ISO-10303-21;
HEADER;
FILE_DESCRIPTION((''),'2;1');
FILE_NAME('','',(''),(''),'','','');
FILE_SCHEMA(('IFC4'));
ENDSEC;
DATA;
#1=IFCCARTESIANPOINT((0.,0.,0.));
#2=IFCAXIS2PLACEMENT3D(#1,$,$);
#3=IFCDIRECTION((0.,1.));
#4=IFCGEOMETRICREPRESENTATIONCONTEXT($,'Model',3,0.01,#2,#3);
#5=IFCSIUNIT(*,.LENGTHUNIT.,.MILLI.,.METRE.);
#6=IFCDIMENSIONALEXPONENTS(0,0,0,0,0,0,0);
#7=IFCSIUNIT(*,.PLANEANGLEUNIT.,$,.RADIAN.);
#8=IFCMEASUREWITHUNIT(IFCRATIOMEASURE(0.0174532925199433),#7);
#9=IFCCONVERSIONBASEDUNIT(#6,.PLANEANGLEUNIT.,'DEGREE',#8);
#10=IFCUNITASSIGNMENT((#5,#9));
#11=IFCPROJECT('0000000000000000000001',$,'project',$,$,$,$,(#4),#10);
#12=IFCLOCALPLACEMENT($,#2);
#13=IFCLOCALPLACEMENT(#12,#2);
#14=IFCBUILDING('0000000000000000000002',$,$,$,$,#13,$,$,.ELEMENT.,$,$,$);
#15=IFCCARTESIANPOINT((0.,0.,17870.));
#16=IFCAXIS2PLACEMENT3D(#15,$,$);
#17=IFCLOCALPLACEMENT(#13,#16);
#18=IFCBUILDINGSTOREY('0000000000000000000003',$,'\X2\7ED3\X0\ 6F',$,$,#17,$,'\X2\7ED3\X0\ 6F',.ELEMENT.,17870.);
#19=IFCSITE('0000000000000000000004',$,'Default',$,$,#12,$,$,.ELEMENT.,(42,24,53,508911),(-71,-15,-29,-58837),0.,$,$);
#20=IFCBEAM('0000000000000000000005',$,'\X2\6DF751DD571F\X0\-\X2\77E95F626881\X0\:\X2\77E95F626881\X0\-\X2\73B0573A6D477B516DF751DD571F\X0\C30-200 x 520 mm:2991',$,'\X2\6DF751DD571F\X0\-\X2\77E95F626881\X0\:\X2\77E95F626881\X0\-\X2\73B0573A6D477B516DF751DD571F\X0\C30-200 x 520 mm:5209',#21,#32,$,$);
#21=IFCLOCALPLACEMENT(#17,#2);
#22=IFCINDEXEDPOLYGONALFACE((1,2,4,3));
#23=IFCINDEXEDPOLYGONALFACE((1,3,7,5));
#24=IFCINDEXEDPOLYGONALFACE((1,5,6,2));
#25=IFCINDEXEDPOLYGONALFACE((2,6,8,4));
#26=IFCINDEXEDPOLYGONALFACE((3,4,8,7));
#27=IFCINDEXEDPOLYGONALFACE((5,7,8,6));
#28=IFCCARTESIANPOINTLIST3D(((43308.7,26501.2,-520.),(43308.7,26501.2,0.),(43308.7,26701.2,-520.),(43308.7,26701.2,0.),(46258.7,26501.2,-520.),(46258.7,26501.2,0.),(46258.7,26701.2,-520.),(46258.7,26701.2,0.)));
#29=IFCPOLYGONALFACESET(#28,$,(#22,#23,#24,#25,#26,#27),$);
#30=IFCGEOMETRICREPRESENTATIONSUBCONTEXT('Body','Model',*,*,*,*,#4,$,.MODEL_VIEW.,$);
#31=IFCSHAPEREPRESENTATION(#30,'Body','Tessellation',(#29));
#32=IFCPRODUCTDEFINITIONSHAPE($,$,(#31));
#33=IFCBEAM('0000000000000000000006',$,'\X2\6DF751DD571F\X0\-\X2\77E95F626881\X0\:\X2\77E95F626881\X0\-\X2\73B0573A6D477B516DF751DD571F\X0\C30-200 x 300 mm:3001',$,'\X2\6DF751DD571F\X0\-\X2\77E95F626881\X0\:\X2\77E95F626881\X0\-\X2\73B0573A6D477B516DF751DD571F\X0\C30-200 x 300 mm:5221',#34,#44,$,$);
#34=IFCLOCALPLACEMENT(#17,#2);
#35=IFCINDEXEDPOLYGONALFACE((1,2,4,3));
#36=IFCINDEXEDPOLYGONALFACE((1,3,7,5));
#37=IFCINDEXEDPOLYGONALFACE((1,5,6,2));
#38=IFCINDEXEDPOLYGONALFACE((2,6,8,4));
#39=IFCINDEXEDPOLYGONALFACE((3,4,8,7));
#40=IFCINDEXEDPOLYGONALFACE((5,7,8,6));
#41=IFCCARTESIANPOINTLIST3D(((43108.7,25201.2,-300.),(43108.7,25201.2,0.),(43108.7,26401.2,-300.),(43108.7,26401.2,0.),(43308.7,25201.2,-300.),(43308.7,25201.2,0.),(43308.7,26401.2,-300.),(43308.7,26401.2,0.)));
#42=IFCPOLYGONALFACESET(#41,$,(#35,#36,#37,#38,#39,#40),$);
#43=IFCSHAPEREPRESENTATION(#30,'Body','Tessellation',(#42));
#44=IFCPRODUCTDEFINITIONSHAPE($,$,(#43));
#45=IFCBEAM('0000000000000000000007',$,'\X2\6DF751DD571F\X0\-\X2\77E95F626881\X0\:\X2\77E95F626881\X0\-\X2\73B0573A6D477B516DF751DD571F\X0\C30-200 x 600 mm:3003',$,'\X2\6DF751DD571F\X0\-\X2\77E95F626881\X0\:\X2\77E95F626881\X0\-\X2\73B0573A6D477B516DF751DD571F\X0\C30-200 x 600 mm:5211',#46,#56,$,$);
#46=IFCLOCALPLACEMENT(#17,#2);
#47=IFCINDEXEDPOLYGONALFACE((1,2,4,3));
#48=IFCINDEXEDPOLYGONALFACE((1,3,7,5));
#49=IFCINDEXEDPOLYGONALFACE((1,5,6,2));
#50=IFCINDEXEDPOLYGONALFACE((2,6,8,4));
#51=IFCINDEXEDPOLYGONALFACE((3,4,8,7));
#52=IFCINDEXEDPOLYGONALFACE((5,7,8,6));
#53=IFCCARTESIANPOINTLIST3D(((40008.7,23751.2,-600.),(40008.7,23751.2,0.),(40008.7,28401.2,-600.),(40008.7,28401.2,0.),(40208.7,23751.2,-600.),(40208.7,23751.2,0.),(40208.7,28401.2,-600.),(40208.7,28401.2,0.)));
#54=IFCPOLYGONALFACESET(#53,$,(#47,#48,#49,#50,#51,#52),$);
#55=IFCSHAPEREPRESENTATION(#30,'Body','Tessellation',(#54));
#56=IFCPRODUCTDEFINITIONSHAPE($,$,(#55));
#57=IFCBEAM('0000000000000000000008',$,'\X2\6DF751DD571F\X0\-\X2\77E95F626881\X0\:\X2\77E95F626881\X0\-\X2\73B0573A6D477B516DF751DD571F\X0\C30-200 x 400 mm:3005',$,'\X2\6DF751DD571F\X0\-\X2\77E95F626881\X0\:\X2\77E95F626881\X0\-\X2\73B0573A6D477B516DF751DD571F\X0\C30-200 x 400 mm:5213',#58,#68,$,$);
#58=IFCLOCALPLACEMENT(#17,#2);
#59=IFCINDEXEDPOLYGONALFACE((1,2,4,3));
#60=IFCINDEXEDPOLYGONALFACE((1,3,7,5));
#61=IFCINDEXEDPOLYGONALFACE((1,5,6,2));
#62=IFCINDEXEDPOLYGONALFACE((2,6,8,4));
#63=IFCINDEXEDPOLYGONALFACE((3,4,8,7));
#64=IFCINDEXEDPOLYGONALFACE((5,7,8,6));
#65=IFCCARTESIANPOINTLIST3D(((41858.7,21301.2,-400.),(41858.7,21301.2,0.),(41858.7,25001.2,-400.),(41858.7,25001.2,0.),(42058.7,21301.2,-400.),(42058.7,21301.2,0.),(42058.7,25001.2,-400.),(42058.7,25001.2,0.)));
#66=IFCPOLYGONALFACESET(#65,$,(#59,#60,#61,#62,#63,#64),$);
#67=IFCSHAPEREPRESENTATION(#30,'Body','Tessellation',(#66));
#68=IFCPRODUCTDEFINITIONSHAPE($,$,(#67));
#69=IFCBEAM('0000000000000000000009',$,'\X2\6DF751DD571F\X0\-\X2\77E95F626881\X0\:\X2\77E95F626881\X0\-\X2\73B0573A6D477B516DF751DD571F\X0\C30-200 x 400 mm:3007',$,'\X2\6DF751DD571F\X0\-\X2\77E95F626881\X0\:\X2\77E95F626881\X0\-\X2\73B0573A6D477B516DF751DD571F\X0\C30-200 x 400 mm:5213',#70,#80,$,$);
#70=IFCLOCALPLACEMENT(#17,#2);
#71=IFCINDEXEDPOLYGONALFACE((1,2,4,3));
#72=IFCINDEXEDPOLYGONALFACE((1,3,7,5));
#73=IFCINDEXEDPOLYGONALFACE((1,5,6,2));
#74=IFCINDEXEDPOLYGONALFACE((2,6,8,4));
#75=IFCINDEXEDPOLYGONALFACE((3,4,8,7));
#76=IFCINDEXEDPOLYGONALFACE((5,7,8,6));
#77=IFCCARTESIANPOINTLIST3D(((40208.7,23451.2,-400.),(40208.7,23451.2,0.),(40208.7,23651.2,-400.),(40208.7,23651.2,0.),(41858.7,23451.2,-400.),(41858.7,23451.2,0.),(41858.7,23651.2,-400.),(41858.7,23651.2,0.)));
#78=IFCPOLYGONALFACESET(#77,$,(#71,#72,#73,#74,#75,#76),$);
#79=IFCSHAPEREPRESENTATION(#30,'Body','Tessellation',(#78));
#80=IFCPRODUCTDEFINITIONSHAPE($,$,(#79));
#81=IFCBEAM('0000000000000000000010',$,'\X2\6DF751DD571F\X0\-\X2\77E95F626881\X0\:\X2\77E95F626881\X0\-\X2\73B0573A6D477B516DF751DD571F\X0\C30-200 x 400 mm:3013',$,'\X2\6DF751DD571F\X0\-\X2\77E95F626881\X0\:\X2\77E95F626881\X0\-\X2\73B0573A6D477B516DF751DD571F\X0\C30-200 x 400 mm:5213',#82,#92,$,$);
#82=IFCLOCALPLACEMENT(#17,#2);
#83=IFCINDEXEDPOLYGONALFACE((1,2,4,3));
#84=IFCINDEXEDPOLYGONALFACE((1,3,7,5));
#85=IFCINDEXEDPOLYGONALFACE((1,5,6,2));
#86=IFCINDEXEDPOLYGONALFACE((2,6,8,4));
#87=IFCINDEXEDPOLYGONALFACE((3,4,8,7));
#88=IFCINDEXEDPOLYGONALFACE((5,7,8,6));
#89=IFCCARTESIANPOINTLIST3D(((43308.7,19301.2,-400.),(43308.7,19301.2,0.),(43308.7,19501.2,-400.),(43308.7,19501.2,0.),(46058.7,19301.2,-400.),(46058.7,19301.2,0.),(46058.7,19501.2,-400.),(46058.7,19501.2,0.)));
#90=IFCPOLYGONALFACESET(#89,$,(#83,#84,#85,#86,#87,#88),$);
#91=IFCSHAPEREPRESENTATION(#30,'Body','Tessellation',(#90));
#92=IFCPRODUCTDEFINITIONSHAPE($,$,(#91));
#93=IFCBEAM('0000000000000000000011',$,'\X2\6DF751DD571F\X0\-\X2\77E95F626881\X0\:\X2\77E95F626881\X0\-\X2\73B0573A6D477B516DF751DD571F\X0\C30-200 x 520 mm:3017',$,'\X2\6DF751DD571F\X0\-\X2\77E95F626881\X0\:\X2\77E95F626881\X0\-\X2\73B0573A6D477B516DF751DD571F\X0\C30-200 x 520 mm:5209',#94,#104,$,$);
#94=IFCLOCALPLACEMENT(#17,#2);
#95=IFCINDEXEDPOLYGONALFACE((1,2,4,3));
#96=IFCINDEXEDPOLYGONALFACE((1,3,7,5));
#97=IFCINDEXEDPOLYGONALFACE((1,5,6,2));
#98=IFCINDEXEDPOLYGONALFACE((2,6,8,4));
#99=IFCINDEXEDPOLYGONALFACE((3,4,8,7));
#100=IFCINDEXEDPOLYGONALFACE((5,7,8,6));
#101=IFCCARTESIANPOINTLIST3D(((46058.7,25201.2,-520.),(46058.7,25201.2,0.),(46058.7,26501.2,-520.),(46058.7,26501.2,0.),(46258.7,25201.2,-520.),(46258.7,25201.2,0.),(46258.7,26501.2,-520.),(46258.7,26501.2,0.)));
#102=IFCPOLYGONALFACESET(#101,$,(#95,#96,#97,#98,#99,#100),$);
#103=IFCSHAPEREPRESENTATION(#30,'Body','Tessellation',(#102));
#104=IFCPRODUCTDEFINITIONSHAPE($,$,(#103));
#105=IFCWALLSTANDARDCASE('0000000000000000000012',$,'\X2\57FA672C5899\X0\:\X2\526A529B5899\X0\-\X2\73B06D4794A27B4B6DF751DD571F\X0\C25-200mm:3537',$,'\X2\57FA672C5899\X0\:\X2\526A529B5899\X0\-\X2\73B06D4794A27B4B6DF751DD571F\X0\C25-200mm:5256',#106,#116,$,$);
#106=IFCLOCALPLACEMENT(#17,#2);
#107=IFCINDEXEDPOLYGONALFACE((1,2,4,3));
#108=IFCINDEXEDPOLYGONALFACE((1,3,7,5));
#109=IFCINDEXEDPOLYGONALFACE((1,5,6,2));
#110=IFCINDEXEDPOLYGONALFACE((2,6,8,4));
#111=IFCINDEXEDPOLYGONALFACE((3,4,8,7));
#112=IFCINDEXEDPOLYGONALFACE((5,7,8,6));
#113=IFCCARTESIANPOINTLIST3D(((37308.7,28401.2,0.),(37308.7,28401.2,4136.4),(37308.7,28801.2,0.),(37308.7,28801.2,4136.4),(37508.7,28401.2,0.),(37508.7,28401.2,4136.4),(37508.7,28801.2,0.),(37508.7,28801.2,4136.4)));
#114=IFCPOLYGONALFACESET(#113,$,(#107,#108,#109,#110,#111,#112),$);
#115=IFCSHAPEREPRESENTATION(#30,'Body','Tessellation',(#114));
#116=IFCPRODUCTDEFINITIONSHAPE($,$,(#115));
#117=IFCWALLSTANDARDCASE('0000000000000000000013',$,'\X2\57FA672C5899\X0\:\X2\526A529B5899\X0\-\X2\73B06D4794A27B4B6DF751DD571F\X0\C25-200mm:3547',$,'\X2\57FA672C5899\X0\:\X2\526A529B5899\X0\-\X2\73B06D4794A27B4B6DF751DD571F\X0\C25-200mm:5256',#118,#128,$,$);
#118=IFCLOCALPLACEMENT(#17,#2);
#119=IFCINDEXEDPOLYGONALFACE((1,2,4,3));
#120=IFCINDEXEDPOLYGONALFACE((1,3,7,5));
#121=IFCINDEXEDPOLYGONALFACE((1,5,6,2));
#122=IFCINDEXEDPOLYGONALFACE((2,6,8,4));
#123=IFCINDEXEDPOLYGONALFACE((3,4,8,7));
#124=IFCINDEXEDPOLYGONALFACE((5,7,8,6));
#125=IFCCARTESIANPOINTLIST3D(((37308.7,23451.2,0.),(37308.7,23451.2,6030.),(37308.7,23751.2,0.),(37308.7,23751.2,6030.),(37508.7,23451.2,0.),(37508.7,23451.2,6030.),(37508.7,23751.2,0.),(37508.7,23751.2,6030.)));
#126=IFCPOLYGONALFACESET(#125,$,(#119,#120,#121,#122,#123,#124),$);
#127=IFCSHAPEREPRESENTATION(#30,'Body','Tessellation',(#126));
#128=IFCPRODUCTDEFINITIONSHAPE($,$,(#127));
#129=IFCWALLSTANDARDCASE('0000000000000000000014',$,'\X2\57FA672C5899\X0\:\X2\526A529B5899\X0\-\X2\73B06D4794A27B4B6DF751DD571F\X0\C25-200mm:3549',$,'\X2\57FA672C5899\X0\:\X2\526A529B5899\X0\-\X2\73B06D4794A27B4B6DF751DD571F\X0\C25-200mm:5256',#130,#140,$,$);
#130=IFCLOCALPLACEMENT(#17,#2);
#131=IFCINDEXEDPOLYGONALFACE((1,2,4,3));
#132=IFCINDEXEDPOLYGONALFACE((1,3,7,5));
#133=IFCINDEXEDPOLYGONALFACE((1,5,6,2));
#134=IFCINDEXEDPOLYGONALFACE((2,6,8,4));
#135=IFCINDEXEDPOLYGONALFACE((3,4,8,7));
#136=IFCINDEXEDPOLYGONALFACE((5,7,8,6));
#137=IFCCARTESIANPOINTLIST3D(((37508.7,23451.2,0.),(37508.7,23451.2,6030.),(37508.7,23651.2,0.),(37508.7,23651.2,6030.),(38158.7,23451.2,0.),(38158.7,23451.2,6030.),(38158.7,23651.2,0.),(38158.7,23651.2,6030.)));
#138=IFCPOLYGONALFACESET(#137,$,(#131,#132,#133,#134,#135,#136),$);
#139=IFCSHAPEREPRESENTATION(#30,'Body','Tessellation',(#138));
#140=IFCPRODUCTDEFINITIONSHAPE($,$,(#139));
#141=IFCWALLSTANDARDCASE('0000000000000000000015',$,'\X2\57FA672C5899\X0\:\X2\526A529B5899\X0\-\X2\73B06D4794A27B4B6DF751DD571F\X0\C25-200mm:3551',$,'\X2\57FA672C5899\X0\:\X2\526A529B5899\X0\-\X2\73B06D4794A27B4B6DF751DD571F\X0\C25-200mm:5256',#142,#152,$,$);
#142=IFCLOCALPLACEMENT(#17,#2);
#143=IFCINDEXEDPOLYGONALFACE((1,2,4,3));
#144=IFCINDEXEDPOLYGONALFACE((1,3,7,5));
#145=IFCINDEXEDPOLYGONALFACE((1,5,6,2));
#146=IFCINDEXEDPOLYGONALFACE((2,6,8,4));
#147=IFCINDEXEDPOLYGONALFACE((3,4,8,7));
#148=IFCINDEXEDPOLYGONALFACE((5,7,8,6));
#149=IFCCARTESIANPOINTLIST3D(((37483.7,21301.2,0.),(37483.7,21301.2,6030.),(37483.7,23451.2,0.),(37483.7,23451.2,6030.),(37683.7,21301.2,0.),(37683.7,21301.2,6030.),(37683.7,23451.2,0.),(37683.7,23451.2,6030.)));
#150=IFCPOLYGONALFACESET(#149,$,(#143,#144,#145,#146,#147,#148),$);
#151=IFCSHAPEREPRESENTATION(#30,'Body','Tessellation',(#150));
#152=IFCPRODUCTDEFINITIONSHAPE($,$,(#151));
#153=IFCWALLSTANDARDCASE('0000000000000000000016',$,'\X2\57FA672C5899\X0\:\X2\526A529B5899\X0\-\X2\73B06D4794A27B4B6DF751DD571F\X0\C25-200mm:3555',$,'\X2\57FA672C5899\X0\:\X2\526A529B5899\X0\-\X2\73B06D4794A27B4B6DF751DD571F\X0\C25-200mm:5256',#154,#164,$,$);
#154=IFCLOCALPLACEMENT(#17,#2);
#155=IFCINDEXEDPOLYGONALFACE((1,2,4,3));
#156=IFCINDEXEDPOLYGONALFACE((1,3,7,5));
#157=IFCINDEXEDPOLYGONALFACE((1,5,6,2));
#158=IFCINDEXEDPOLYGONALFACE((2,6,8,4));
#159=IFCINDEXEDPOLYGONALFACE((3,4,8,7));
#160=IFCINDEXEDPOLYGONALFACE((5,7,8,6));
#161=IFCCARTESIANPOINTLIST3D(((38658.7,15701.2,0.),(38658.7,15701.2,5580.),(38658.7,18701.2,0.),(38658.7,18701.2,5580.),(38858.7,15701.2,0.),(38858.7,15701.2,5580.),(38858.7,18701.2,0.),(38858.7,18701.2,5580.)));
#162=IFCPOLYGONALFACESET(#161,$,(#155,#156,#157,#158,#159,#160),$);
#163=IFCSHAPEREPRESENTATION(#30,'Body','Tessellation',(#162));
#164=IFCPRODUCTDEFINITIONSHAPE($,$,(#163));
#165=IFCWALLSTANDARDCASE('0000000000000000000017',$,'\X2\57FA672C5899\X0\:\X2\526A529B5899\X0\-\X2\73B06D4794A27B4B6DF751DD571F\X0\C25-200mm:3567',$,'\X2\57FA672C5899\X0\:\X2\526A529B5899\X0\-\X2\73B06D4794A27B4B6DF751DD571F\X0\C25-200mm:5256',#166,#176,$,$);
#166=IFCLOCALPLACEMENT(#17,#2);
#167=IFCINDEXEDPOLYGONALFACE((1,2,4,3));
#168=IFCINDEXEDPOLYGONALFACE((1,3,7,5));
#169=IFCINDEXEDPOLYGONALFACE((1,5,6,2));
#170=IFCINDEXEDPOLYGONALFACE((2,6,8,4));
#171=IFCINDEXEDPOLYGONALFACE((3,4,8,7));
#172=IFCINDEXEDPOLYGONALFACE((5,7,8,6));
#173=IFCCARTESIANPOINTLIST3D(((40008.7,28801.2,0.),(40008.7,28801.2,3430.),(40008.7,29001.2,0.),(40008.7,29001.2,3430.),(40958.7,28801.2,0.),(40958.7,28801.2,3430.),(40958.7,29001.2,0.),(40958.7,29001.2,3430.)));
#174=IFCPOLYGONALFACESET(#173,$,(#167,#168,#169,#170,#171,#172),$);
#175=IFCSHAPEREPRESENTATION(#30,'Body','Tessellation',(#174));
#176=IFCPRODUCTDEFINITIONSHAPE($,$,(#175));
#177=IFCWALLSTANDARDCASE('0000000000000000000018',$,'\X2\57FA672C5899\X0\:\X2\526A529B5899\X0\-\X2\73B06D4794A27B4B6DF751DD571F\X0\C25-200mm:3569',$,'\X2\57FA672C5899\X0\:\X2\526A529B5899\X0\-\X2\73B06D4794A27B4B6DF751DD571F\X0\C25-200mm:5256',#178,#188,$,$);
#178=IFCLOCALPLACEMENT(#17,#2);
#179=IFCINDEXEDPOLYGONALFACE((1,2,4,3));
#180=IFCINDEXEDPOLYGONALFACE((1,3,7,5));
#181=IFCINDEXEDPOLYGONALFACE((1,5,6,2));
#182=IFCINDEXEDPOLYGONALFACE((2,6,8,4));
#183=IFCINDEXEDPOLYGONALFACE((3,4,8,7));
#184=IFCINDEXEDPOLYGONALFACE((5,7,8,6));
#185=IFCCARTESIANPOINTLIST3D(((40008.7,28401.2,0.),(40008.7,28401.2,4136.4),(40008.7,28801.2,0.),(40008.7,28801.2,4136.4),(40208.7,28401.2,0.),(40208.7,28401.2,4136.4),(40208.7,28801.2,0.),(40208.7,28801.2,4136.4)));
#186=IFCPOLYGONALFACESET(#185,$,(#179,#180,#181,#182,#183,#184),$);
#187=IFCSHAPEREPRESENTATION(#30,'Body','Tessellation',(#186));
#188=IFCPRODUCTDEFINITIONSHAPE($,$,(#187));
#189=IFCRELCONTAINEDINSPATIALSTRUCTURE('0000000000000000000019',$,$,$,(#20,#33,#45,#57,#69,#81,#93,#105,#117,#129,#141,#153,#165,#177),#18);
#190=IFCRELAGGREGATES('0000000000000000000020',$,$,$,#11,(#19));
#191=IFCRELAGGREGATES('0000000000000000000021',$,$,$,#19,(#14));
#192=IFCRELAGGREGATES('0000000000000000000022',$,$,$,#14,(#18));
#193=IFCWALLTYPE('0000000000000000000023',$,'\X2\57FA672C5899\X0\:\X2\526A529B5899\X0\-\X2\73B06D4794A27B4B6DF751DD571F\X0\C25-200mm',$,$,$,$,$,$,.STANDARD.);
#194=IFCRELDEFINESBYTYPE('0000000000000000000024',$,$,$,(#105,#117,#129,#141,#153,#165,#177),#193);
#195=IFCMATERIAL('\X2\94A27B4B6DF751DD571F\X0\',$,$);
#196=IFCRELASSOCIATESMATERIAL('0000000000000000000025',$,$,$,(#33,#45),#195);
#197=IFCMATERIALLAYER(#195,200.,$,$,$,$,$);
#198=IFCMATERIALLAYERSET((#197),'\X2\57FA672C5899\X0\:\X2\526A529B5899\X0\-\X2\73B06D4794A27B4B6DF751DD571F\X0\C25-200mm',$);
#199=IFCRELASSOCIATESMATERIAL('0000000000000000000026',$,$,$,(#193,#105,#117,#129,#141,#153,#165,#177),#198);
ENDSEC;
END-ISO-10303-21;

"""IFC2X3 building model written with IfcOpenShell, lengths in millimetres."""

from ifc_helpers import new_model, entity, si_unit, converted_unit, direction, frame, frame_2d, origin, origin_2d_with_axis, place, context, subcontext, project, spatial, rectangle, extrude, material, layer, layer_set, layer_usage, type_object, element, save


model = new_model("IFC2X3")

# Units and contexts
model_context = context("Model", 3, precision=0.01, world=origin(), true_north=direction((0.0, 1.0)))
body_context = subcontext(model_context, "Body", "Model", "MODEL_VIEW")
ifc_project = project(units=[si_unit("LENGTHUNIT", "METRE", prefix="MILLI"), converted_unit("PLANEANGLEUNIT", "DEGREE", entity("IfcRatioMeasure", 0.0174532925199433), si_unit("PLANEANGLEUNIT", "RADIAN"), dimensions=[0, 0, 0, 0, 0, 0, 0])], contexts=[model_context])

# Site, building, storey
site_placement = place(None, origin())
site = spatial("IfcSite", under=ifc_project, at=site_placement, Name="Default", CompositionType="ELEMENT", RefLatitude=(42, 24, 53, 508911), RefLongitude=(-71, -15, -29, -58837), RefElevation=0.0)
building_placement = place(site_placement, origin())
building = spatial("IfcBuilding", under=site, at=building_placement, CompositionType="ELEMENT")
storey_placement = place(building_placement, frame((0.0, 0.0, 17870.0)))
storey = spatial("IfcBuildingStorey", under=building, at=storey_placement, Name="结 6F", LongName="结 6F", CompositionType="ELEMENT", Elevation=17870.0)

# Beams
ifc_material = material(Name="钢筋混凝土")
beam_1_placement = place(storey_placement, frame((46158.7, 26601.2, 0.0), z_axis=(0.0, 0.0, 1.0), x_axis=(-1.0, 0.0, 0.0)))
element("IfcBeam", 1, at=beam_1_placement, inside=storey, Name="混凝土-矩形梁:矩形梁-现场浇筑混凝土C30-200 x 520 mm:2991", ObjectType="混凝土-矩形梁:矩形梁-现场浇筑混凝土C30-200 x 520 mm:5209", context=body_context, shape_type="SweptSolid", body=[
    extrude(rectangle(XDim=520.0, YDim=200.0, at=frame_2d((0.0, 0.0), x_axis=(1.0, 0.0))), frame((-100.0, 0.0, -260.0), z_axis=(1.0, 0.0, 0.0), x_axis=(0.0, 0.0, -1.0)), (0.0, 0.0, 1.0), 2950.0),
])
beam_2_placement = place(storey_placement, frame((43208.7, 25101.2, 0.0), z_axis=(0.0, 0.0, 1.0), x_axis=(0.0, 1.0, 0.0)))
element("IfcBeam", 2, at=beam_2_placement, inside=storey, material=ifc_material, Name="混凝土-矩形梁:矩形梁-现场浇筑混凝土C30-200 x 300 mm:3001", ObjectType="混凝土-矩形梁:矩形梁-现场浇筑混凝土C30-200 x 300 mm:5221", context=body_context, shape_type="SweptSolid", body=[
    extrude(rectangle(XDim=300.0, YDim=200.0, at=frame_2d((0.0, 0.0), x_axis=(1.0, 0.0))), frame((100.0, 0.0, -150.0), z_axis=(1.0, 0.0, 0.0), x_axis=(0.0, 0.0, -1.0)), (0.0, 0.0, 1.0), 1200.0),
])
beam_3_placement = place(storey_placement, frame((40108.7, 23551.2, 0.0), z_axis=(0.0, 0.0, 1.0), x_axis=(0.0, 1.0, 0.0)))
element("IfcBeam", 3, at=beam_3_placement, inside=storey, material=ifc_material, Name="混凝土-矩形梁:矩形梁-现场浇筑混凝土C30-200 x 600 mm:3003", ObjectType="混凝土-矩形梁:矩形梁-现场浇筑混凝土C30-200 x 600 mm:5211", context=body_context, shape_type="SweptSolid", body=[
    extrude(rectangle(XDim=600.0, YDim=200.0, at=frame_2d((0.0, 0.0), x_axis=(1.0, 0.0))), frame((200.0, 0.0, -300.0), z_axis=(1.0, 0.0, 0.0), x_axis=(0.0, 0.0, -1.0)), (0.0, 0.0, 1.0), 4650.0),
])
beam_4_placement = place(storey_placement, frame((41958.7, 21201.2, 0.0), z_axis=(0.0, 0.0, 1.0), x_axis=(0.0, 1.0, 0.0)))
element("IfcBeam", 4, at=beam_4_placement, inside=storey, Name="混凝土-矩形梁:矩形梁-现场浇筑混凝土C30-200 x 400 mm:3005", ObjectType="混凝土-矩形梁:矩形梁-现场浇筑混凝土C30-200 x 400 mm:5213", context=body_context, shape_type="SweptSolid", body=[
    extrude(rectangle(XDim=400.0, YDim=200.0, at=origin_2d_with_axis()), frame((100.0, 0.0, -200.0), z_axis=(1.0, 0.0, 0.0), x_axis=(0.0, 0.0, -1.0)), (0.0, 0.0, 1.0), 3700.0),
])
beam_5_placement = place(storey_placement, frame((40108.7, 23551.2, 0.0)))
element("IfcBeam", 5, at=beam_5_placement, inside=storey, Name="混凝土-矩形梁:矩形梁-现场浇筑混凝土C30-200 x 400 mm:3007", ObjectType="混凝土-矩形梁:矩形梁-现场浇筑混凝土C30-200 x 400 mm:5213", context=body_context, shape_type="SweptSolid", body=[
    extrude(rectangle(XDim=400.0, YDim=200.0, at=frame_2d((0.0, 0.0), x_axis=(1.0, 0.0))), frame((100.0, 0.0, -200.0), z_axis=(1.0, 0.0, 0.0), x_axis=(0.0, 0.0, -1.0)), (0.0, 0.0, 1.0), 1650.0),
])
beam_6_placement = place(storey_placement, frame((46158.7, 19401.2, 0.0), z_axis=(0.0, 0.0, 1.0), x_axis=(-1.0, 0.0, 0.0)))
element("IfcBeam", 6, at=beam_6_placement, inside=storey, Name="混凝土-矩形梁:矩形梁-现场浇筑混凝土C30-200 x 400 mm:3013", ObjectType="混凝土-矩形梁:矩形梁-现场浇筑混凝土C30-200 x 400 mm:5213", context=body_context, shape_type="SweptSolid", body=[
    extrude(rectangle(XDim=400.0, YDim=200.0, at=frame_2d((0.0, 0.0), x_axis=(1.0, 0.0))), frame((100.0, 0.0, -200.0), z_axis=(1.0, 0.0, 0.0), x_axis=(0.0, 0.0, -1.0)), (0.0, 0.0, 1.0), 2750.0),
])
beam_7_placement = place(storey_placement, frame((46158.7, 25101.2, 0.0), z_axis=(0.0, 0.0, 1.0), x_axis=(0.0, 1.0, 0.0)))
element("IfcBeam", 7, at=beam_7_placement, inside=storey, Name="混凝土-矩形梁:矩形梁-现场浇筑混凝土C30-200 x 520 mm:3017", ObjectType="混凝土-矩形梁:矩形梁-现场浇筑混凝土C30-200 x 520 mm:5209", context=body_context, shape_type="SweptSolid", body=[
    extrude(rectangle(XDim=520.0, YDim=200.0, at=frame_2d((0.0, 0.0), x_axis=(1.0, 0.0))), frame((100.0, 0.0, -260.0), z_axis=(1.0, 0.0, 0.0), x_axis=(0.0, 0.0, -1.0)), (0.0, 0.0, 1.0), 1300.0),
])

# Walls
ifc_layer = layer(ifc_material, 200.0)
ifc_layer_set = layer_set([ifc_layer], Name="基本墙:剪力墙-现浇钢筋混凝土C25-200mm")
ifc_layer_usage_1 = layer_usage(ifc_layer_set, "AXIS2", "NEGATIVE", 100.0)
wall_type = type_object("IfcWallType", Name="基本墙:剪力墙-现浇钢筋混凝土C25-200mm", PredefinedType="STANDARD", material=ifc_layer_set)
wall_1_placement = place(storey_placement, frame((37408.7, 28801.2, 0.0), z_axis=(0.0, 0.0, 1.0), x_axis=(0.0, -1.0, 0.0)))
element("IfcWallStandardCase", 8, at=wall_1_placement, inside=storey, type_object=wall_type, material=ifc_layer_usage_1, Name="基本墙:剪力墙-现浇钢筋混凝土C25-200mm:3537", ObjectType="基本墙:剪力墙-现浇钢筋混凝土C25-200mm:5256", context=body_context, shape_type="SweptSolid", body=[
    extrude(rectangle(XDim=400.0, YDim=200.0, at=frame_2d((200.0, 0.0), x_axis=(-1.0, 0.0))), origin(), (0.0, 0.0, 1.0), 4136.4),
])
ifc_layer_usage_2 = layer_usage(ifc_layer_set, "AXIS2", "NEGATIVE", 100.0)
wall_2_placement = place(storey_placement, frame((37408.7, 23751.2, 0.0), z_axis=(0.0, 0.0, 1.0), x_axis=(0.0, -1.0, 0.0)))
element("IfcWallStandardCase", 9, at=wall_2_placement, inside=storey, type_object=wall_type, material=ifc_layer_usage_2, Name="基本墙:剪力墙-现浇钢筋混凝土C25-200mm:3547", ObjectType="基本墙:剪力墙-现浇钢筋混凝土C25-200mm:5256", context=body_context, shape_type="SweptSolid", body=[
    extrude(rectangle(XDim=300.0, YDim=200.0, at=frame_2d((150.0, 0.0), x_axis=(-1.0, 0.0))), origin(), (0.0, 0.0, 1.0), 6030.0),
])
ifc_layer_usage_3 = layer_usage(ifc_layer_set, "AXIS2", "NEGATIVE", 100.0)
wall_3_placement = place(storey_placement, frame((37508.7, 23551.2, 0.0)))
element("IfcWallStandardCase", 10, at=wall_3_placement, inside=storey, type_object=wall_type, material=ifc_layer_usage_3, Name="基本墙:剪力墙-现浇钢筋混凝土C25-200mm:3549", ObjectType="基本墙:剪力墙-现浇钢筋混凝土C25-200mm:5256", context=body_context, shape_type="SweptSolid", body=[
    extrude(rectangle(XDim=650.0, YDim=200.0, at=frame_2d((325.0, 0.0), x_axis=(-1.0, 0.0))), origin(), (0.0, 0.0, 1.0), 6030.0),
])
ifc_layer_usage_4 = layer_usage(ifc_layer_set, "AXIS2", "NEGATIVE", 100.0)
wall_4_placement = place(storey_placement, frame((37583.7, 23451.2, 0.0), z_axis=(0.0, 0.0, 1.0), x_axis=(0.0, -1.0, 0.0)))
element("IfcWallStandardCase", 11, at=wall_4_placement, inside=storey, type_object=wall_type, material=ifc_layer_usage_4, Name="基本墙:剪力墙-现浇钢筋混凝土C25-200mm:3551", ObjectType="基本墙:剪力墙-现浇钢筋混凝土C25-200mm:5256", context=body_context, shape_type="SweptSolid", body=[
    extrude(rectangle(XDim=2150.0, YDim=200.0, at=frame_2d((1075.0, 0.0), x_axis=(-1.0, 0.0))), origin(), (0.0, 0.0, 1.0), 6030.0),
])
ifc_layer_usage_5 = layer_usage(ifc_layer_set, "AXIS2", "NEGATIVE", 100.0)
wall_5_placement = place(storey_placement, frame((38758.7, 15701.2, 0.0), z_axis=(0.0, 0.0, 1.0), x_axis=(0.0, 1.0, 0.0)))
element("IfcWallStandardCase", 12, at=wall_5_placement, inside=storey, type_object=wall_type, material=ifc_layer_usage_5, Name="基本墙:剪力墙-现浇钢筋混凝土C25-200mm:3555", ObjectType="基本墙:剪力墙-现浇钢筋混凝土C25-200mm:5256", context=body_context, shape_type="SweptSolid", body=[
    extrude(rectangle(XDim=3000.0, YDim=200.0, at=frame_2d((1500.0, 0.0), x_axis=(-1.0, 0.0))), origin(), (0.0, 0.0, 1.0), 5580.0),
])
ifc_layer_usage_6 = layer_usage(ifc_layer_set, "AXIS2", "POSITIVE", -100.0)
wall_6_placement = place(storey_placement, frame((40958.7, 28901.2, 0.0), z_axis=(0.0, 0.0, 1.0), x_axis=(-1.0, 0.0, 0.0)))
element("IfcWallStandardCase", 13, at=wall_6_placement, inside=storey, type_object=wall_type, material=ifc_layer_usage_6, Name="基本墙:剪力墙-现浇钢筋混凝土C25-200mm:3567", ObjectType="基本墙:剪力墙-现浇钢筋混凝土C25-200mm:5256", context=body_context, shape_type="SweptSolid", body=[
    extrude(rectangle(XDim=950.0, YDim=200.0, at=frame_2d((475.0, 0.0), x_axis=(-1.0, 0.0))), origin(), (0.0, 0.0, 1.0), 3430.0),
])
ifc_layer_usage_7 = layer_usage(ifc_layer_set, "AXIS2", "POSITIVE", -100.0)
wall_7_placement = place(storey_placement, frame((40108.7, 28801.2, 0.0), z_axis=(0.0, 0.0, 1.0), x_axis=(0.0, -1.0, 0.0)))
element("IfcWallStandardCase", 14, at=wall_7_placement, inside=storey, type_object=wall_type, material=ifc_layer_usage_7, Name="基本墙:剪力墙-现浇钢筋混凝土C25-200mm:3569", ObjectType="基本墙:剪力墙-现浇钢筋混凝土C25-200mm:5256", context=body_context, shape_type="SweptSolid", body=[
    extrude(rectangle(XDim=400.0, YDim=200.0, at=frame_2d((200.0, 0.0), x_axis=(-1.0, 0.0))), origin(), (0.0, 0.0, 1.0), 4136.4),
])

save(model, "model.ifc")
